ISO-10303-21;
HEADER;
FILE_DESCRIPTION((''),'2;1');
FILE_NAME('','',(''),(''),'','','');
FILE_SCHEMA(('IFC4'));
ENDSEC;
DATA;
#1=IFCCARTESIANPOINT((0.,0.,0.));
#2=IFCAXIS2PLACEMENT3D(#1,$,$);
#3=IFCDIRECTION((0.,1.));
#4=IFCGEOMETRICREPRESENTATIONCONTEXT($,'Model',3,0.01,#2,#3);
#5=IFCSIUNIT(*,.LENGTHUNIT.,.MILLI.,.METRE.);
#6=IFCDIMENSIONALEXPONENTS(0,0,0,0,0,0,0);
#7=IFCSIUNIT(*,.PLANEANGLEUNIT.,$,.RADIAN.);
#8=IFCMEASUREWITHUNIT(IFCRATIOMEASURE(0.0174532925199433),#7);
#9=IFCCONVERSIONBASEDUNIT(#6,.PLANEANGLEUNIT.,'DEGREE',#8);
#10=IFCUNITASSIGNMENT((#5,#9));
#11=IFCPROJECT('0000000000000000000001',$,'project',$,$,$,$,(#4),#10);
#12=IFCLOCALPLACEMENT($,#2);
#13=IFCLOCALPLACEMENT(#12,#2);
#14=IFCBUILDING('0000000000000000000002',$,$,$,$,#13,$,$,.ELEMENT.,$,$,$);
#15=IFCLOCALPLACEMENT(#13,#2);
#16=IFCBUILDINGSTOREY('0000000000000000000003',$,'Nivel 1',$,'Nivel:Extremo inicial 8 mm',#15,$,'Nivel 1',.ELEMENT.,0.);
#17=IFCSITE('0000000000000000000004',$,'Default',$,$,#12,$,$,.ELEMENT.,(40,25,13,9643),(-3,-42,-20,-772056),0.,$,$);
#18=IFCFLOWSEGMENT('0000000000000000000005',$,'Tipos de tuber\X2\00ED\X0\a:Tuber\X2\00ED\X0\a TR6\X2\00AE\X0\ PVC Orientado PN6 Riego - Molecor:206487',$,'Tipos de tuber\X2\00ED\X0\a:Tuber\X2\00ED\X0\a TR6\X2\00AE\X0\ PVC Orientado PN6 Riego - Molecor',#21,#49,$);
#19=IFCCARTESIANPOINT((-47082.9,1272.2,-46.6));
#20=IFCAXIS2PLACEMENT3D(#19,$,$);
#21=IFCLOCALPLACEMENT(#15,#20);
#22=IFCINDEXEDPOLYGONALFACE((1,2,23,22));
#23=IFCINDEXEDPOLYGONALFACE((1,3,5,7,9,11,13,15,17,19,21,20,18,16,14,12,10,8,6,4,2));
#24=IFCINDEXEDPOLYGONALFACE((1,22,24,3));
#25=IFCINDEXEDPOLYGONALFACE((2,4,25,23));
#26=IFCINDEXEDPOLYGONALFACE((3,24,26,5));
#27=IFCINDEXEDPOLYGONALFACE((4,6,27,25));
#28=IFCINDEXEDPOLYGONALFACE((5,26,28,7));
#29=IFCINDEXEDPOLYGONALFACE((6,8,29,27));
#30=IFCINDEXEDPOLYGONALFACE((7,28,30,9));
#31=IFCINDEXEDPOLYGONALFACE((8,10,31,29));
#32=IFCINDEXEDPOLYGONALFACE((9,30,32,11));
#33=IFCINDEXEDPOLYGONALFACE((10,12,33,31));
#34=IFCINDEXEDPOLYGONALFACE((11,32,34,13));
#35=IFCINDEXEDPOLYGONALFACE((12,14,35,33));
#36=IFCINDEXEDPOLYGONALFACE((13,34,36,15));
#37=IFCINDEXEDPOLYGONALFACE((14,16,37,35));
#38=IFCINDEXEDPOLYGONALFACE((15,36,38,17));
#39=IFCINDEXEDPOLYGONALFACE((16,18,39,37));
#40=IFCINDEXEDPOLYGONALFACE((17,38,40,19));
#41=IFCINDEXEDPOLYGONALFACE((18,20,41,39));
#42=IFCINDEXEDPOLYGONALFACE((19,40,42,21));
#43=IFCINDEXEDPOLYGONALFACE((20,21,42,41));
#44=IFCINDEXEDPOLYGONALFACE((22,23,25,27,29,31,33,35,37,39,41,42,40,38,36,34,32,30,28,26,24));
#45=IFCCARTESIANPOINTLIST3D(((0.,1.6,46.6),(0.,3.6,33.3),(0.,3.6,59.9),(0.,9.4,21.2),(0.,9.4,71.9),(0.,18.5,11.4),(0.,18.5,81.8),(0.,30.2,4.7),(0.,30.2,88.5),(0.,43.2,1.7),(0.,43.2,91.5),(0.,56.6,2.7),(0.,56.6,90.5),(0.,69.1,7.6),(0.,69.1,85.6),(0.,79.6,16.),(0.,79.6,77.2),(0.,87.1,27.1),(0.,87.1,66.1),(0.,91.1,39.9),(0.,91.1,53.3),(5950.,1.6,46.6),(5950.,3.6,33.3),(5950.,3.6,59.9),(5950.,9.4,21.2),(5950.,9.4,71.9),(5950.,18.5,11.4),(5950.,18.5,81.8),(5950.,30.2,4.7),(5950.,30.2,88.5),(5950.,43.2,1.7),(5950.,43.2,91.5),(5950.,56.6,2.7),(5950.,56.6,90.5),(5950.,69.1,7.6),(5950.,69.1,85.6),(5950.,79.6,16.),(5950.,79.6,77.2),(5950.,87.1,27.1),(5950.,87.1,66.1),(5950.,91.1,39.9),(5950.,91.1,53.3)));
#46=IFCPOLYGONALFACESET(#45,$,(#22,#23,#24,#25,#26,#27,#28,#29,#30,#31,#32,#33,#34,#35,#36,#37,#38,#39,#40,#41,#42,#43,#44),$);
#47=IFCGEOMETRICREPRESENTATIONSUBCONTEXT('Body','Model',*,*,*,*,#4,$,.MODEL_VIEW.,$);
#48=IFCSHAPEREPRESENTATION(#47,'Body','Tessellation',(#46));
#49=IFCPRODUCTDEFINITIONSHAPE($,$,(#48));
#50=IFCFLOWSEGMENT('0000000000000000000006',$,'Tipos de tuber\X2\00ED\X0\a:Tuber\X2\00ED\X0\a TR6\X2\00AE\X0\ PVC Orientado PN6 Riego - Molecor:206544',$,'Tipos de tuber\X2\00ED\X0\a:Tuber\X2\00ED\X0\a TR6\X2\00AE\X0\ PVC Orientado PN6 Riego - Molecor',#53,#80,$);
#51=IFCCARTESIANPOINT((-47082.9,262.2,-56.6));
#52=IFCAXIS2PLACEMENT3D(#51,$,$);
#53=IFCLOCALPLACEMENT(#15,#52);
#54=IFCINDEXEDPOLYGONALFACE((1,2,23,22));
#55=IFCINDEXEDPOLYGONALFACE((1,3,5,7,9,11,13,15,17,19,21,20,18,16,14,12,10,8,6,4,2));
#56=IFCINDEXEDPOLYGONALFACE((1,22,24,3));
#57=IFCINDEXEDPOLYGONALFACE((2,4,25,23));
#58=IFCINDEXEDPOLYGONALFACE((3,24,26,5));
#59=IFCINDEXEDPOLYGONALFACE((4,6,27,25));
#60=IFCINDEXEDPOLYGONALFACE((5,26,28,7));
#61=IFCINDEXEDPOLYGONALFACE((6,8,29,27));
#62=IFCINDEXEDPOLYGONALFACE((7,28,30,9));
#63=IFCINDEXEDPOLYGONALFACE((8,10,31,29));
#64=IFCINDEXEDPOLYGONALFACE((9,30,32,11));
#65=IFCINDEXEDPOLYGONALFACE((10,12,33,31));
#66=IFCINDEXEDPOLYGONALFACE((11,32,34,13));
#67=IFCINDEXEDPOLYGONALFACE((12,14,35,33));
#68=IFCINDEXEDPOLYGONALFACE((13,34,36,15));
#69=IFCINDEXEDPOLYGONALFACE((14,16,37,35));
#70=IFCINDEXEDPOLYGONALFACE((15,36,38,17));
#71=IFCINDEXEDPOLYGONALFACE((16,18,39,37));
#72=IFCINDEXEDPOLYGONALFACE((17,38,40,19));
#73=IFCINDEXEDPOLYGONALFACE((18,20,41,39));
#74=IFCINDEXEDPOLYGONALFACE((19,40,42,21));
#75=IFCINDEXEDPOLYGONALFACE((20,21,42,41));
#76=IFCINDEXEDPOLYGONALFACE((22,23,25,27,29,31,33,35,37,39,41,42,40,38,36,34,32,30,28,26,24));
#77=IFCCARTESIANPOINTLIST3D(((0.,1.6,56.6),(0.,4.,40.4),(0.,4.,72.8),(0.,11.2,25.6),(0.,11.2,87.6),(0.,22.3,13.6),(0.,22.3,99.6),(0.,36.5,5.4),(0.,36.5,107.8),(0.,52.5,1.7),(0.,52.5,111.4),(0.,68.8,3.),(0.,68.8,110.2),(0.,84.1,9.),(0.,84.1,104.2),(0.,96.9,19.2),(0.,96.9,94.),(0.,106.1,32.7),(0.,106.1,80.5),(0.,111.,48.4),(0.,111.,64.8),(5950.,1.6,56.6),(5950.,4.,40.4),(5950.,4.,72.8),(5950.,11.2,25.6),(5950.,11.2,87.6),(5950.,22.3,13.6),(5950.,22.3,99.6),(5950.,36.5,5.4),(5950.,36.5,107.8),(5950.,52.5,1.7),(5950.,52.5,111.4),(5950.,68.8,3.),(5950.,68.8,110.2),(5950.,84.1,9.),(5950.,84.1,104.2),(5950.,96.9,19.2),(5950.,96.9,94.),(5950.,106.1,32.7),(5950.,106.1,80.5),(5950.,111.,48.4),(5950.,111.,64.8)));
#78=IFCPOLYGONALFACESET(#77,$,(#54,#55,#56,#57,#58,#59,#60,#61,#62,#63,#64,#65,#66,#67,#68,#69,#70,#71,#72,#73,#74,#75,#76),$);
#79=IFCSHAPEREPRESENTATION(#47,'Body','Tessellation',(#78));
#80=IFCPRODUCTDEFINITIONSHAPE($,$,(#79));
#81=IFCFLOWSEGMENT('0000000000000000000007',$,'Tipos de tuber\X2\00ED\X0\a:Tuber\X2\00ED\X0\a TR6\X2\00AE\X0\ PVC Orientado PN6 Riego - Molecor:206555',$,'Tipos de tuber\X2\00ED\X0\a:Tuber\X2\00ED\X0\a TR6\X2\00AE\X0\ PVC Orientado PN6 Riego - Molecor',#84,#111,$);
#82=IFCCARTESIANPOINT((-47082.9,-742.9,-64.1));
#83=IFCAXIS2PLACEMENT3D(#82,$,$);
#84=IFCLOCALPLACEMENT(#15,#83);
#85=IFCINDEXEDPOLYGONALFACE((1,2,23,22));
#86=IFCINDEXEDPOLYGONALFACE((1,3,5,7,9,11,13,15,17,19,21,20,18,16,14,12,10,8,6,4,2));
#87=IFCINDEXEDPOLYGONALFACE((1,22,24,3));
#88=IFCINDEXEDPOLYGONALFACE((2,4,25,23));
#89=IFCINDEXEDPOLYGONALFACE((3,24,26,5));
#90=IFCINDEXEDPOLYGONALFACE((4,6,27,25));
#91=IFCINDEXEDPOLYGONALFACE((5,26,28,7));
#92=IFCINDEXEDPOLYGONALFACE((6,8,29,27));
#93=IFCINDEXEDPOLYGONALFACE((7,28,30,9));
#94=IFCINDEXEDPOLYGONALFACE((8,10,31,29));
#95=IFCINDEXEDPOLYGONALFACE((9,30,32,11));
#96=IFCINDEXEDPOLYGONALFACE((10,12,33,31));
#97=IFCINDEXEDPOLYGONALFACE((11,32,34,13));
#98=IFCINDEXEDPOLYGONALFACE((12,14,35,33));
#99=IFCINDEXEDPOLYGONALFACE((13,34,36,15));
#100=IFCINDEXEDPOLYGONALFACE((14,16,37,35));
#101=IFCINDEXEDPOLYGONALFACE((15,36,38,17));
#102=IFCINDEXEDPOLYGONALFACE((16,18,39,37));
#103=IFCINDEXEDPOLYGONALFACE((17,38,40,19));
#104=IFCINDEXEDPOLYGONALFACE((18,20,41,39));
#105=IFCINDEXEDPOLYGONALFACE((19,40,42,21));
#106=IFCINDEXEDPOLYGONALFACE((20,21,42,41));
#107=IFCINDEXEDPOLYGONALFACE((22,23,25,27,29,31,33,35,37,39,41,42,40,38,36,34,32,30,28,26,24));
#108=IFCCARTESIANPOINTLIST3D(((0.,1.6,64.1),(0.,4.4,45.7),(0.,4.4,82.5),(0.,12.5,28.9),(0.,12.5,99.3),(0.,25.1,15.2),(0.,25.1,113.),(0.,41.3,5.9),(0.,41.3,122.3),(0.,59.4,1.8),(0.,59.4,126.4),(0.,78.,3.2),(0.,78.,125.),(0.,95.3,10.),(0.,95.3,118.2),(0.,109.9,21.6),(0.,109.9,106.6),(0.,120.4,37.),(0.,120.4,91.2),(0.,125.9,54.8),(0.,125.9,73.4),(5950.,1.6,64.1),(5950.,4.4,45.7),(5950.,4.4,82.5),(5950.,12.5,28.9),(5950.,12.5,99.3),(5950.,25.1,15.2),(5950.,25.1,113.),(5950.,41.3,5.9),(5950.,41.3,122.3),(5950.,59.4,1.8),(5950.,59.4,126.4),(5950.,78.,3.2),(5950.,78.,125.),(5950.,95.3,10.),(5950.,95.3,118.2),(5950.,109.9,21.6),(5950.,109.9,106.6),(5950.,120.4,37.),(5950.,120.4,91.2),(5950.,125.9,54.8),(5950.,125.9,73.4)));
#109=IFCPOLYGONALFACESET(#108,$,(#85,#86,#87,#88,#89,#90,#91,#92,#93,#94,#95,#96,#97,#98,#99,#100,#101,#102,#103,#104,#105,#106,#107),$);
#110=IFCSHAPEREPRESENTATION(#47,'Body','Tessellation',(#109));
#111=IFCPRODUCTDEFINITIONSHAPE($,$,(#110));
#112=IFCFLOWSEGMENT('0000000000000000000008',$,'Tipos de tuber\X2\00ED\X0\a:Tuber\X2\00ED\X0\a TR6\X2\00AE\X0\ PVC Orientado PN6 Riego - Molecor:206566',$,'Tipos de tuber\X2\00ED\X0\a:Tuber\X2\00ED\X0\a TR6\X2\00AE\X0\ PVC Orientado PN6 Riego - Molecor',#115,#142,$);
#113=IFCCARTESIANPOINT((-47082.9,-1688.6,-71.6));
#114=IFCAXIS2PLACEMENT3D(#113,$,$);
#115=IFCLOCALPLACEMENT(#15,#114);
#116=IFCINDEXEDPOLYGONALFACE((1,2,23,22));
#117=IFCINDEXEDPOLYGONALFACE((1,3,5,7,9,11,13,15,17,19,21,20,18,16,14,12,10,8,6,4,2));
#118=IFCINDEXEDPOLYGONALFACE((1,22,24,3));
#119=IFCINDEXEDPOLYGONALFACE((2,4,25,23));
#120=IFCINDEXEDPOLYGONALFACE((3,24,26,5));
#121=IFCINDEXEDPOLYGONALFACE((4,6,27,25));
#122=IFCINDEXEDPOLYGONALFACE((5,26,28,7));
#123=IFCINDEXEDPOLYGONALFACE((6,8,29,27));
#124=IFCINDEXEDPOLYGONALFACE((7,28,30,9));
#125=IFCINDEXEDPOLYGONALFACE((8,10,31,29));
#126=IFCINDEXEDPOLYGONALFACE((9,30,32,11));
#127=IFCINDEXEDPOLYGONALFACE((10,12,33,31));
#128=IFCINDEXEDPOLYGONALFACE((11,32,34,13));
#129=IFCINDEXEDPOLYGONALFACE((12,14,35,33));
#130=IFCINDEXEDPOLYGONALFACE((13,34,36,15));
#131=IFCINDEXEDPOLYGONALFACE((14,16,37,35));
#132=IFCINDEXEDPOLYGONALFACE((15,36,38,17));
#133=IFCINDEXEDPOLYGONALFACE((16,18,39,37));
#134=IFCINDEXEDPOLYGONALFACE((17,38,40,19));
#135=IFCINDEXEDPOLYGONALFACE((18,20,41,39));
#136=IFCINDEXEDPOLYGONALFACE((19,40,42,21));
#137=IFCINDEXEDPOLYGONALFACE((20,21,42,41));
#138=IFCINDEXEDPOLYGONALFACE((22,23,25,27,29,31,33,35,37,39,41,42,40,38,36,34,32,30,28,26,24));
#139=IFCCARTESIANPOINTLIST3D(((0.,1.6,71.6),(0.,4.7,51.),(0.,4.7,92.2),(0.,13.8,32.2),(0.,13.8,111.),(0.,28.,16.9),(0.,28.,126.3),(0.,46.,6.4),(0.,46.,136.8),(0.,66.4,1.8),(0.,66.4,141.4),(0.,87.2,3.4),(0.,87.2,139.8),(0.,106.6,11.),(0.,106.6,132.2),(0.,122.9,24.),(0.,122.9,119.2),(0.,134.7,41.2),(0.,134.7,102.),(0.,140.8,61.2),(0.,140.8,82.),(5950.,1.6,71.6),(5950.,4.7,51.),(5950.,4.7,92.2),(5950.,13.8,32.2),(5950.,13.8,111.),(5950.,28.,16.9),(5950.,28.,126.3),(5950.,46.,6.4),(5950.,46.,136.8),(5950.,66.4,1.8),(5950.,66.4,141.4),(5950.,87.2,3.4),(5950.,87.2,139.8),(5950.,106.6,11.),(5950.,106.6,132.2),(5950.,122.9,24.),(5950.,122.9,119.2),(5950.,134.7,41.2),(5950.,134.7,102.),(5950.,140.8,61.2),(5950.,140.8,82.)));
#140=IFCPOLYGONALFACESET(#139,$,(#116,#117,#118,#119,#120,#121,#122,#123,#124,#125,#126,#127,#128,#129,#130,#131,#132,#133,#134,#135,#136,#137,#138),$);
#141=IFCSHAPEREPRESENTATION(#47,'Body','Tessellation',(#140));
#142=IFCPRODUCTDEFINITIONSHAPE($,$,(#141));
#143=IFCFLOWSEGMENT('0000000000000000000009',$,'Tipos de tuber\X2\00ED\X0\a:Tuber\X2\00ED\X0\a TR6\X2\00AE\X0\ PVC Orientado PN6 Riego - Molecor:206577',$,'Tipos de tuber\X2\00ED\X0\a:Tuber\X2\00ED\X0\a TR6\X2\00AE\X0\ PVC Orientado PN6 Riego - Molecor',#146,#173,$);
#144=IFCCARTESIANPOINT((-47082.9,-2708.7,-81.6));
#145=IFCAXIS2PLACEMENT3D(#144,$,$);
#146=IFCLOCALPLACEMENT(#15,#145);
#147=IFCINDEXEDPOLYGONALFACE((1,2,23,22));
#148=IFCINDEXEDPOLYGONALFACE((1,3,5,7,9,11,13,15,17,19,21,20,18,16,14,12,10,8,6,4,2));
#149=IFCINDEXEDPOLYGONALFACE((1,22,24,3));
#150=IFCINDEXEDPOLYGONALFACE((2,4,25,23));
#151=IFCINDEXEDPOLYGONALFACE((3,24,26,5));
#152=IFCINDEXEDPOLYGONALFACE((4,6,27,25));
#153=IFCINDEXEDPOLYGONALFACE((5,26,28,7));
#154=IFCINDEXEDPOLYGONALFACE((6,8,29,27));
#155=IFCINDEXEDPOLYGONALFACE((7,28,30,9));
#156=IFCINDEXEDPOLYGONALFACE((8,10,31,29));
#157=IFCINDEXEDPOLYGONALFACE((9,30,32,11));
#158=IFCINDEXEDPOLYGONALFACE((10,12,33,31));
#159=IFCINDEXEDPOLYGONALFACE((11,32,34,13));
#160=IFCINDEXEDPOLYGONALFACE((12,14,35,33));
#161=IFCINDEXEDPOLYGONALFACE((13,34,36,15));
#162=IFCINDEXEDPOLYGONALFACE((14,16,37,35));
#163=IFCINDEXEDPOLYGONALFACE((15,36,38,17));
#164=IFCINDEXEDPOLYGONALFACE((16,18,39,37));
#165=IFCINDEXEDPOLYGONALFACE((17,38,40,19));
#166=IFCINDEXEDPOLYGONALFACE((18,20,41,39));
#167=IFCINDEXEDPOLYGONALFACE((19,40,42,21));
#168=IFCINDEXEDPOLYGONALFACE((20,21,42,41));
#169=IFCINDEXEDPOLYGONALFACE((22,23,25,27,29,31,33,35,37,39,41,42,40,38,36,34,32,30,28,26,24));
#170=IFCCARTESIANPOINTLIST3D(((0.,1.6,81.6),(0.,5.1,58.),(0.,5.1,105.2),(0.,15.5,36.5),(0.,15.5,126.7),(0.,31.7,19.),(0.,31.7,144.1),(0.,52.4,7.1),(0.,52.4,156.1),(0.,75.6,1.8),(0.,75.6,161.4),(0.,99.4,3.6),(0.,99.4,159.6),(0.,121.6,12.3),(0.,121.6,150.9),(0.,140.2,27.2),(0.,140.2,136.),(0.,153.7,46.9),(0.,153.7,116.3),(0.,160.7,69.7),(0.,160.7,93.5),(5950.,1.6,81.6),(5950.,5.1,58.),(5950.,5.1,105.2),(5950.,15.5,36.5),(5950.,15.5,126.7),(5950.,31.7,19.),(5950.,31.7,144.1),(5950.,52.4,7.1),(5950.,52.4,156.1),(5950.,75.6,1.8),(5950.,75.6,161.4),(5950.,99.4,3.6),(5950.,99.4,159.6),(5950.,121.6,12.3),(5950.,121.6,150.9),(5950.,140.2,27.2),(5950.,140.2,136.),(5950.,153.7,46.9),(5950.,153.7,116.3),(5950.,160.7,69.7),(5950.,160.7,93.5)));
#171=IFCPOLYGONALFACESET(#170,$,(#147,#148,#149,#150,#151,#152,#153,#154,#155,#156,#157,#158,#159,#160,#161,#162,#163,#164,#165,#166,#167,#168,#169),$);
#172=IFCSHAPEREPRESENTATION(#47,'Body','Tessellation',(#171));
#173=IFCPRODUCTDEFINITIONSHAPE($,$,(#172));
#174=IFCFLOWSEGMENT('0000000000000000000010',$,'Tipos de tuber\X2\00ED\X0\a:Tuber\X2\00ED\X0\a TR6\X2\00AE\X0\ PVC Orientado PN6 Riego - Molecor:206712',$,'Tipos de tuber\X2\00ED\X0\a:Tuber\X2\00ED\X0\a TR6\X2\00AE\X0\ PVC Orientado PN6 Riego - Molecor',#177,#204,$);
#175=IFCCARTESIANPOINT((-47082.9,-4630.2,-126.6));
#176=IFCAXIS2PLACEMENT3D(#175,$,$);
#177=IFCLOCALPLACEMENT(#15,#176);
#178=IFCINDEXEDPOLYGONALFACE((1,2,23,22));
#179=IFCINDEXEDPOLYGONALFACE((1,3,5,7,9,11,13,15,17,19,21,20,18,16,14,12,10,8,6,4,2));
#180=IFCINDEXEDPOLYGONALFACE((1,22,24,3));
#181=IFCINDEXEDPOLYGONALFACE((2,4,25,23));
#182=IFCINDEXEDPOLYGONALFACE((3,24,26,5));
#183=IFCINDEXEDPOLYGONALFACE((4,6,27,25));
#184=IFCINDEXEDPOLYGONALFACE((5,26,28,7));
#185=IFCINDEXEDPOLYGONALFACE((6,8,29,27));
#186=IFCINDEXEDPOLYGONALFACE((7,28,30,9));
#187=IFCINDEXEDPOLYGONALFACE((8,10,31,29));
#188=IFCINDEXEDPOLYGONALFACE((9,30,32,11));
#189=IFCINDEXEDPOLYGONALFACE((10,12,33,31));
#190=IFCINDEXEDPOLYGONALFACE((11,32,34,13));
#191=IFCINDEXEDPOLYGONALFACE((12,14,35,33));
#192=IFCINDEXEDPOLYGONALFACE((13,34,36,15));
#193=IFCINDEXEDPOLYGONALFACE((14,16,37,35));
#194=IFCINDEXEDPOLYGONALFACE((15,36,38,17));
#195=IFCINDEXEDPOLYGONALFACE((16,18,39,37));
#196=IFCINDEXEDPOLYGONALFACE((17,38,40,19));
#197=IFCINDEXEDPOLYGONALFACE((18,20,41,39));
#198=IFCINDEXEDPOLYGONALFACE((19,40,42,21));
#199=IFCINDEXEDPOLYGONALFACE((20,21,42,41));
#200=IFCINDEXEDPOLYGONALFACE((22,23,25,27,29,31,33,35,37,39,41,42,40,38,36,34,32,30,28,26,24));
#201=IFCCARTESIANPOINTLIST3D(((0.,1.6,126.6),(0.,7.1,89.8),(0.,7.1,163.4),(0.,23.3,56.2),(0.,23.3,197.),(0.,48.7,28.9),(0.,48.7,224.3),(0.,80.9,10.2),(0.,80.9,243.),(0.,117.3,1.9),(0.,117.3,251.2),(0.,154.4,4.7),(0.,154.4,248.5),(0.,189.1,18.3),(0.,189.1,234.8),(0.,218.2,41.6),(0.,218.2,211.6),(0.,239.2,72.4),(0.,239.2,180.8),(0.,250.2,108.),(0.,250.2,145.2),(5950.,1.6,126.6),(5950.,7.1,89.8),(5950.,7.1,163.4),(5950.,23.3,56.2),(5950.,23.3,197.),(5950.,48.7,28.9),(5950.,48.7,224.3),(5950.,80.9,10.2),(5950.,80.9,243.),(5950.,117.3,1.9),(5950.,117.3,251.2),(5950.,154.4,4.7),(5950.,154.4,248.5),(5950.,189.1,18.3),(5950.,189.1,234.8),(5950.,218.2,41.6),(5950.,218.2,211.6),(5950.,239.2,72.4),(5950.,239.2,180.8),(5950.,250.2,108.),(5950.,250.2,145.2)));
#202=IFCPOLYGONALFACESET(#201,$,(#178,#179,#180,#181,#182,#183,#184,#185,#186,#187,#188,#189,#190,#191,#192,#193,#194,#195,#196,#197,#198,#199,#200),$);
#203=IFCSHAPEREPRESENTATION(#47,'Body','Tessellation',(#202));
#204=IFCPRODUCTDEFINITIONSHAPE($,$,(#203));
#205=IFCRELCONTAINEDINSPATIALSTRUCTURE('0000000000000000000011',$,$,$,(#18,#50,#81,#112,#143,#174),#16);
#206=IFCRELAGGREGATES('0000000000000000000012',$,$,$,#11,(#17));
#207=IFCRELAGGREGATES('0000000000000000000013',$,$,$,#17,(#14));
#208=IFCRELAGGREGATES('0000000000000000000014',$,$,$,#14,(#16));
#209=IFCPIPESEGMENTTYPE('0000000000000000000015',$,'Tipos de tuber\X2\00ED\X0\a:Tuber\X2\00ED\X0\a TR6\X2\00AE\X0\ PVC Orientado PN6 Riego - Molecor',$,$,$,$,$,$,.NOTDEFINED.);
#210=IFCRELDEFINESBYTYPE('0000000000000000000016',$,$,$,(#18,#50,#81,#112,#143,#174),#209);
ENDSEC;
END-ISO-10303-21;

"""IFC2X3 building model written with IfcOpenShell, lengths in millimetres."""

from ifc_helpers import new_model, entity, si_unit, converted_unit, direction, frame, frame_2d, origin, place, context, subcontext, project, spatial, circle, extrude, type_object, element, save


model = new_model("IFC2X3")

# Units and contexts
model_context = context("Model", 3, precision=0.01, world=origin(), true_north=direction((0.0, 1.0)))
body_context = subcontext(model_context, "Body", "Model", "MODEL_VIEW")
ifc_project = project(units=[si_unit("LENGTHUNIT", "METRE", prefix="MILLI"), converted_unit("PLANEANGLEUNIT", "DEGREE", entity("IfcRatioMeasure", 0.0174532925199433), si_unit("PLANEANGLEUNIT", "RADIAN"), dimensions=[0, 0, 0, 0, 0, 0, 0])], contexts=[model_context])

# Site, building, storey
site_placement = place(None, origin())
site = spatial("IfcSite", under=ifc_project, at=site_placement, Name="Default", CompositionType="ELEMENT", RefLatitude=(40, 25, 13, 9643), RefLongitude=(-3, -42, -20, -772056), RefElevation=0.0)
building_placement = place(site_placement, origin())
building = spatial("IfcBuilding", under=site, at=building_placement, CompositionType="ELEMENT")
storey_placement = place(building_placement, origin())
storey = spatial("IfcBuildingStorey", under=building, at=storey_placement, Name="Nivel 1", ObjectType="Nivel:Extremo inicial 8 mm", LongName="Nivel 1", CompositionType="ELEMENT", Elevation=0.0)

# Flow segments
pipe_segment_type = type_object("IfcPipeSegmentType", Name="Tipos de tubería:Tubería TR6® PVC Orientado PN6 Riego - Molecor", PredefinedType="NOTDEFINED")
flow_segment_1_placement = place(storey_placement, frame((-47082.9, 1272.2, -46.6)))
element("IfcFlowSegment", 1, at=flow_segment_1_placement, inside=storey, type_object=pipe_segment_type, Name="Tipos de tubería:Tubería TR6® PVC Orientado PN6 Riego - Molecor:206487", ObjectType="Tipos de tubería:Tubería TR6® PVC Orientado PN6 Riego - Molecor", context=body_context, shape_type="SweptSolid", body=[
    extrude(circle(Radius=45.0, at=frame_2d((0.0, 0.0), x_axis=(1.0, 0.0))), frame((0.0, 46.6, 46.6), z_axis=(1.0, 0.0, 0.0), x_axis=(0.0, -1.0, 0.0)), (0.0, 0.0, 1.0), 5950.0),
])
flow_segment_2_placement = place(storey_placement, frame((-47082.9, 262.2, -56.6)))
element("IfcFlowSegment", 2, at=flow_segment_2_placement, inside=storey, type_object=pipe_segment_type, Name="Tipos de tubería:Tubería TR6® PVC Orientado PN6 Riego - Molecor:206544", ObjectType="Tipos de tubería:Tubería TR6® PVC Orientado PN6 Riego - Molecor", context=body_context, shape_type="SweptSolid", body=[
    extrude(circle(Radius=55.0, at=frame_2d((0.0, 0.0), x_axis=(1.0, 0.0))), frame((0.0, 56.6, 56.6), z_axis=(1.0, 0.0, 0.0), x_axis=(0.0, -1.0, 0.0)), (0.0, 0.0, 1.0), 5950.0),
])
flow_segment_3_placement = place(storey_placement, frame((-47082.9, -742.9, -64.1)))
element("IfcFlowSegment", 3, at=flow_segment_3_placement, inside=storey, type_object=pipe_segment_type, Name="Tipos de tubería:Tubería TR6® PVC Orientado PN6 Riego - Molecor:206555", ObjectType="Tipos de tubería:Tubería TR6® PVC Orientado PN6 Riego - Molecor", context=body_context, shape_type="SweptSolid", body=[
    extrude(circle(Radius=62.5, at=frame_2d((0.0, 0.0), x_axis=(1.0, 0.0))), frame((0.0, 64.1, 64.1), z_axis=(1.0, 0.0, 0.0), x_axis=(0.0, -1.0, 0.0)), (0.0, 0.0, 1.0), 5950.0),
])
flow_segment_4_placement = place(storey_placement, frame((-47082.9, -1688.6, -71.6)))
element("IfcFlowSegment", 4, at=flow_segment_4_placement, inside=storey, type_object=pipe_segment_type, Name="Tipos de tubería:Tubería TR6® PVC Orientado PN6 Riego - Molecor:206566", ObjectType="Tipos de tubería:Tubería TR6® PVC Orientado PN6 Riego - Molecor", context=body_context, shape_type="SweptSolid", body=[
    extrude(circle(Radius=70.0, at=frame_2d((0.0, 0.0), x_axis=(1.0, 0.0))), frame((0.0, 71.6, 71.6), z_axis=(1.0, 0.0, 0.0), x_axis=(0.0, -1.0, 0.0)), (0.0, 0.0, 1.0), 5950.0),
])
flow_segment_5_placement = place(storey_placement, frame((-47082.9, -2708.7, -81.6)))
element("IfcFlowSegment", 5, at=flow_segment_5_placement, inside=storey, type_object=pipe_segment_type, Name="Tipos de tubería:Tubería TR6® PVC Orientado PN6 Riego - Molecor:206577", ObjectType="Tipos de tubería:Tubería TR6® PVC Orientado PN6 Riego - Molecor", context=body_context, shape_type="SweptSolid", body=[
    extrude(circle(Radius=80.0, at=frame_2d((0.0, 0.0), x_axis=(1.0, 0.0))), frame((0.0, 81.6, 81.6), z_axis=(1.0, 0.0, 0.0), x_axis=(0.0, -1.0, 0.0)), (0.0, 0.0, 1.0), 5950.0),
])
flow_segment_6_placement = place(storey_placement, frame((-47082.9, -4630.2, -126.6)))
element("IfcFlowSegment", 6, at=flow_segment_6_placement, inside=storey, type_object=pipe_segment_type, Name="Tipos de tubería:Tubería TR6® PVC Orientado PN6 Riego - Molecor:206712", ObjectType="Tipos de tubería:Tubería TR6® PVC Orientado PN6 Riego - Molecor", context=body_context, shape_type="SweptSolid", body=[
    extrude(circle(Radius=125.0, at=frame_2d((0.0, 0.0), x_axis=(1.0, 0.0))), frame((0.0, 126.6, 126.6), z_axis=(1.0, 0.0, 0.0), x_axis=(0.0, -1.0, 0.0)), (0.0, 0.0, 1.0), 5950.0),
])

save(model, "model.ifc")
